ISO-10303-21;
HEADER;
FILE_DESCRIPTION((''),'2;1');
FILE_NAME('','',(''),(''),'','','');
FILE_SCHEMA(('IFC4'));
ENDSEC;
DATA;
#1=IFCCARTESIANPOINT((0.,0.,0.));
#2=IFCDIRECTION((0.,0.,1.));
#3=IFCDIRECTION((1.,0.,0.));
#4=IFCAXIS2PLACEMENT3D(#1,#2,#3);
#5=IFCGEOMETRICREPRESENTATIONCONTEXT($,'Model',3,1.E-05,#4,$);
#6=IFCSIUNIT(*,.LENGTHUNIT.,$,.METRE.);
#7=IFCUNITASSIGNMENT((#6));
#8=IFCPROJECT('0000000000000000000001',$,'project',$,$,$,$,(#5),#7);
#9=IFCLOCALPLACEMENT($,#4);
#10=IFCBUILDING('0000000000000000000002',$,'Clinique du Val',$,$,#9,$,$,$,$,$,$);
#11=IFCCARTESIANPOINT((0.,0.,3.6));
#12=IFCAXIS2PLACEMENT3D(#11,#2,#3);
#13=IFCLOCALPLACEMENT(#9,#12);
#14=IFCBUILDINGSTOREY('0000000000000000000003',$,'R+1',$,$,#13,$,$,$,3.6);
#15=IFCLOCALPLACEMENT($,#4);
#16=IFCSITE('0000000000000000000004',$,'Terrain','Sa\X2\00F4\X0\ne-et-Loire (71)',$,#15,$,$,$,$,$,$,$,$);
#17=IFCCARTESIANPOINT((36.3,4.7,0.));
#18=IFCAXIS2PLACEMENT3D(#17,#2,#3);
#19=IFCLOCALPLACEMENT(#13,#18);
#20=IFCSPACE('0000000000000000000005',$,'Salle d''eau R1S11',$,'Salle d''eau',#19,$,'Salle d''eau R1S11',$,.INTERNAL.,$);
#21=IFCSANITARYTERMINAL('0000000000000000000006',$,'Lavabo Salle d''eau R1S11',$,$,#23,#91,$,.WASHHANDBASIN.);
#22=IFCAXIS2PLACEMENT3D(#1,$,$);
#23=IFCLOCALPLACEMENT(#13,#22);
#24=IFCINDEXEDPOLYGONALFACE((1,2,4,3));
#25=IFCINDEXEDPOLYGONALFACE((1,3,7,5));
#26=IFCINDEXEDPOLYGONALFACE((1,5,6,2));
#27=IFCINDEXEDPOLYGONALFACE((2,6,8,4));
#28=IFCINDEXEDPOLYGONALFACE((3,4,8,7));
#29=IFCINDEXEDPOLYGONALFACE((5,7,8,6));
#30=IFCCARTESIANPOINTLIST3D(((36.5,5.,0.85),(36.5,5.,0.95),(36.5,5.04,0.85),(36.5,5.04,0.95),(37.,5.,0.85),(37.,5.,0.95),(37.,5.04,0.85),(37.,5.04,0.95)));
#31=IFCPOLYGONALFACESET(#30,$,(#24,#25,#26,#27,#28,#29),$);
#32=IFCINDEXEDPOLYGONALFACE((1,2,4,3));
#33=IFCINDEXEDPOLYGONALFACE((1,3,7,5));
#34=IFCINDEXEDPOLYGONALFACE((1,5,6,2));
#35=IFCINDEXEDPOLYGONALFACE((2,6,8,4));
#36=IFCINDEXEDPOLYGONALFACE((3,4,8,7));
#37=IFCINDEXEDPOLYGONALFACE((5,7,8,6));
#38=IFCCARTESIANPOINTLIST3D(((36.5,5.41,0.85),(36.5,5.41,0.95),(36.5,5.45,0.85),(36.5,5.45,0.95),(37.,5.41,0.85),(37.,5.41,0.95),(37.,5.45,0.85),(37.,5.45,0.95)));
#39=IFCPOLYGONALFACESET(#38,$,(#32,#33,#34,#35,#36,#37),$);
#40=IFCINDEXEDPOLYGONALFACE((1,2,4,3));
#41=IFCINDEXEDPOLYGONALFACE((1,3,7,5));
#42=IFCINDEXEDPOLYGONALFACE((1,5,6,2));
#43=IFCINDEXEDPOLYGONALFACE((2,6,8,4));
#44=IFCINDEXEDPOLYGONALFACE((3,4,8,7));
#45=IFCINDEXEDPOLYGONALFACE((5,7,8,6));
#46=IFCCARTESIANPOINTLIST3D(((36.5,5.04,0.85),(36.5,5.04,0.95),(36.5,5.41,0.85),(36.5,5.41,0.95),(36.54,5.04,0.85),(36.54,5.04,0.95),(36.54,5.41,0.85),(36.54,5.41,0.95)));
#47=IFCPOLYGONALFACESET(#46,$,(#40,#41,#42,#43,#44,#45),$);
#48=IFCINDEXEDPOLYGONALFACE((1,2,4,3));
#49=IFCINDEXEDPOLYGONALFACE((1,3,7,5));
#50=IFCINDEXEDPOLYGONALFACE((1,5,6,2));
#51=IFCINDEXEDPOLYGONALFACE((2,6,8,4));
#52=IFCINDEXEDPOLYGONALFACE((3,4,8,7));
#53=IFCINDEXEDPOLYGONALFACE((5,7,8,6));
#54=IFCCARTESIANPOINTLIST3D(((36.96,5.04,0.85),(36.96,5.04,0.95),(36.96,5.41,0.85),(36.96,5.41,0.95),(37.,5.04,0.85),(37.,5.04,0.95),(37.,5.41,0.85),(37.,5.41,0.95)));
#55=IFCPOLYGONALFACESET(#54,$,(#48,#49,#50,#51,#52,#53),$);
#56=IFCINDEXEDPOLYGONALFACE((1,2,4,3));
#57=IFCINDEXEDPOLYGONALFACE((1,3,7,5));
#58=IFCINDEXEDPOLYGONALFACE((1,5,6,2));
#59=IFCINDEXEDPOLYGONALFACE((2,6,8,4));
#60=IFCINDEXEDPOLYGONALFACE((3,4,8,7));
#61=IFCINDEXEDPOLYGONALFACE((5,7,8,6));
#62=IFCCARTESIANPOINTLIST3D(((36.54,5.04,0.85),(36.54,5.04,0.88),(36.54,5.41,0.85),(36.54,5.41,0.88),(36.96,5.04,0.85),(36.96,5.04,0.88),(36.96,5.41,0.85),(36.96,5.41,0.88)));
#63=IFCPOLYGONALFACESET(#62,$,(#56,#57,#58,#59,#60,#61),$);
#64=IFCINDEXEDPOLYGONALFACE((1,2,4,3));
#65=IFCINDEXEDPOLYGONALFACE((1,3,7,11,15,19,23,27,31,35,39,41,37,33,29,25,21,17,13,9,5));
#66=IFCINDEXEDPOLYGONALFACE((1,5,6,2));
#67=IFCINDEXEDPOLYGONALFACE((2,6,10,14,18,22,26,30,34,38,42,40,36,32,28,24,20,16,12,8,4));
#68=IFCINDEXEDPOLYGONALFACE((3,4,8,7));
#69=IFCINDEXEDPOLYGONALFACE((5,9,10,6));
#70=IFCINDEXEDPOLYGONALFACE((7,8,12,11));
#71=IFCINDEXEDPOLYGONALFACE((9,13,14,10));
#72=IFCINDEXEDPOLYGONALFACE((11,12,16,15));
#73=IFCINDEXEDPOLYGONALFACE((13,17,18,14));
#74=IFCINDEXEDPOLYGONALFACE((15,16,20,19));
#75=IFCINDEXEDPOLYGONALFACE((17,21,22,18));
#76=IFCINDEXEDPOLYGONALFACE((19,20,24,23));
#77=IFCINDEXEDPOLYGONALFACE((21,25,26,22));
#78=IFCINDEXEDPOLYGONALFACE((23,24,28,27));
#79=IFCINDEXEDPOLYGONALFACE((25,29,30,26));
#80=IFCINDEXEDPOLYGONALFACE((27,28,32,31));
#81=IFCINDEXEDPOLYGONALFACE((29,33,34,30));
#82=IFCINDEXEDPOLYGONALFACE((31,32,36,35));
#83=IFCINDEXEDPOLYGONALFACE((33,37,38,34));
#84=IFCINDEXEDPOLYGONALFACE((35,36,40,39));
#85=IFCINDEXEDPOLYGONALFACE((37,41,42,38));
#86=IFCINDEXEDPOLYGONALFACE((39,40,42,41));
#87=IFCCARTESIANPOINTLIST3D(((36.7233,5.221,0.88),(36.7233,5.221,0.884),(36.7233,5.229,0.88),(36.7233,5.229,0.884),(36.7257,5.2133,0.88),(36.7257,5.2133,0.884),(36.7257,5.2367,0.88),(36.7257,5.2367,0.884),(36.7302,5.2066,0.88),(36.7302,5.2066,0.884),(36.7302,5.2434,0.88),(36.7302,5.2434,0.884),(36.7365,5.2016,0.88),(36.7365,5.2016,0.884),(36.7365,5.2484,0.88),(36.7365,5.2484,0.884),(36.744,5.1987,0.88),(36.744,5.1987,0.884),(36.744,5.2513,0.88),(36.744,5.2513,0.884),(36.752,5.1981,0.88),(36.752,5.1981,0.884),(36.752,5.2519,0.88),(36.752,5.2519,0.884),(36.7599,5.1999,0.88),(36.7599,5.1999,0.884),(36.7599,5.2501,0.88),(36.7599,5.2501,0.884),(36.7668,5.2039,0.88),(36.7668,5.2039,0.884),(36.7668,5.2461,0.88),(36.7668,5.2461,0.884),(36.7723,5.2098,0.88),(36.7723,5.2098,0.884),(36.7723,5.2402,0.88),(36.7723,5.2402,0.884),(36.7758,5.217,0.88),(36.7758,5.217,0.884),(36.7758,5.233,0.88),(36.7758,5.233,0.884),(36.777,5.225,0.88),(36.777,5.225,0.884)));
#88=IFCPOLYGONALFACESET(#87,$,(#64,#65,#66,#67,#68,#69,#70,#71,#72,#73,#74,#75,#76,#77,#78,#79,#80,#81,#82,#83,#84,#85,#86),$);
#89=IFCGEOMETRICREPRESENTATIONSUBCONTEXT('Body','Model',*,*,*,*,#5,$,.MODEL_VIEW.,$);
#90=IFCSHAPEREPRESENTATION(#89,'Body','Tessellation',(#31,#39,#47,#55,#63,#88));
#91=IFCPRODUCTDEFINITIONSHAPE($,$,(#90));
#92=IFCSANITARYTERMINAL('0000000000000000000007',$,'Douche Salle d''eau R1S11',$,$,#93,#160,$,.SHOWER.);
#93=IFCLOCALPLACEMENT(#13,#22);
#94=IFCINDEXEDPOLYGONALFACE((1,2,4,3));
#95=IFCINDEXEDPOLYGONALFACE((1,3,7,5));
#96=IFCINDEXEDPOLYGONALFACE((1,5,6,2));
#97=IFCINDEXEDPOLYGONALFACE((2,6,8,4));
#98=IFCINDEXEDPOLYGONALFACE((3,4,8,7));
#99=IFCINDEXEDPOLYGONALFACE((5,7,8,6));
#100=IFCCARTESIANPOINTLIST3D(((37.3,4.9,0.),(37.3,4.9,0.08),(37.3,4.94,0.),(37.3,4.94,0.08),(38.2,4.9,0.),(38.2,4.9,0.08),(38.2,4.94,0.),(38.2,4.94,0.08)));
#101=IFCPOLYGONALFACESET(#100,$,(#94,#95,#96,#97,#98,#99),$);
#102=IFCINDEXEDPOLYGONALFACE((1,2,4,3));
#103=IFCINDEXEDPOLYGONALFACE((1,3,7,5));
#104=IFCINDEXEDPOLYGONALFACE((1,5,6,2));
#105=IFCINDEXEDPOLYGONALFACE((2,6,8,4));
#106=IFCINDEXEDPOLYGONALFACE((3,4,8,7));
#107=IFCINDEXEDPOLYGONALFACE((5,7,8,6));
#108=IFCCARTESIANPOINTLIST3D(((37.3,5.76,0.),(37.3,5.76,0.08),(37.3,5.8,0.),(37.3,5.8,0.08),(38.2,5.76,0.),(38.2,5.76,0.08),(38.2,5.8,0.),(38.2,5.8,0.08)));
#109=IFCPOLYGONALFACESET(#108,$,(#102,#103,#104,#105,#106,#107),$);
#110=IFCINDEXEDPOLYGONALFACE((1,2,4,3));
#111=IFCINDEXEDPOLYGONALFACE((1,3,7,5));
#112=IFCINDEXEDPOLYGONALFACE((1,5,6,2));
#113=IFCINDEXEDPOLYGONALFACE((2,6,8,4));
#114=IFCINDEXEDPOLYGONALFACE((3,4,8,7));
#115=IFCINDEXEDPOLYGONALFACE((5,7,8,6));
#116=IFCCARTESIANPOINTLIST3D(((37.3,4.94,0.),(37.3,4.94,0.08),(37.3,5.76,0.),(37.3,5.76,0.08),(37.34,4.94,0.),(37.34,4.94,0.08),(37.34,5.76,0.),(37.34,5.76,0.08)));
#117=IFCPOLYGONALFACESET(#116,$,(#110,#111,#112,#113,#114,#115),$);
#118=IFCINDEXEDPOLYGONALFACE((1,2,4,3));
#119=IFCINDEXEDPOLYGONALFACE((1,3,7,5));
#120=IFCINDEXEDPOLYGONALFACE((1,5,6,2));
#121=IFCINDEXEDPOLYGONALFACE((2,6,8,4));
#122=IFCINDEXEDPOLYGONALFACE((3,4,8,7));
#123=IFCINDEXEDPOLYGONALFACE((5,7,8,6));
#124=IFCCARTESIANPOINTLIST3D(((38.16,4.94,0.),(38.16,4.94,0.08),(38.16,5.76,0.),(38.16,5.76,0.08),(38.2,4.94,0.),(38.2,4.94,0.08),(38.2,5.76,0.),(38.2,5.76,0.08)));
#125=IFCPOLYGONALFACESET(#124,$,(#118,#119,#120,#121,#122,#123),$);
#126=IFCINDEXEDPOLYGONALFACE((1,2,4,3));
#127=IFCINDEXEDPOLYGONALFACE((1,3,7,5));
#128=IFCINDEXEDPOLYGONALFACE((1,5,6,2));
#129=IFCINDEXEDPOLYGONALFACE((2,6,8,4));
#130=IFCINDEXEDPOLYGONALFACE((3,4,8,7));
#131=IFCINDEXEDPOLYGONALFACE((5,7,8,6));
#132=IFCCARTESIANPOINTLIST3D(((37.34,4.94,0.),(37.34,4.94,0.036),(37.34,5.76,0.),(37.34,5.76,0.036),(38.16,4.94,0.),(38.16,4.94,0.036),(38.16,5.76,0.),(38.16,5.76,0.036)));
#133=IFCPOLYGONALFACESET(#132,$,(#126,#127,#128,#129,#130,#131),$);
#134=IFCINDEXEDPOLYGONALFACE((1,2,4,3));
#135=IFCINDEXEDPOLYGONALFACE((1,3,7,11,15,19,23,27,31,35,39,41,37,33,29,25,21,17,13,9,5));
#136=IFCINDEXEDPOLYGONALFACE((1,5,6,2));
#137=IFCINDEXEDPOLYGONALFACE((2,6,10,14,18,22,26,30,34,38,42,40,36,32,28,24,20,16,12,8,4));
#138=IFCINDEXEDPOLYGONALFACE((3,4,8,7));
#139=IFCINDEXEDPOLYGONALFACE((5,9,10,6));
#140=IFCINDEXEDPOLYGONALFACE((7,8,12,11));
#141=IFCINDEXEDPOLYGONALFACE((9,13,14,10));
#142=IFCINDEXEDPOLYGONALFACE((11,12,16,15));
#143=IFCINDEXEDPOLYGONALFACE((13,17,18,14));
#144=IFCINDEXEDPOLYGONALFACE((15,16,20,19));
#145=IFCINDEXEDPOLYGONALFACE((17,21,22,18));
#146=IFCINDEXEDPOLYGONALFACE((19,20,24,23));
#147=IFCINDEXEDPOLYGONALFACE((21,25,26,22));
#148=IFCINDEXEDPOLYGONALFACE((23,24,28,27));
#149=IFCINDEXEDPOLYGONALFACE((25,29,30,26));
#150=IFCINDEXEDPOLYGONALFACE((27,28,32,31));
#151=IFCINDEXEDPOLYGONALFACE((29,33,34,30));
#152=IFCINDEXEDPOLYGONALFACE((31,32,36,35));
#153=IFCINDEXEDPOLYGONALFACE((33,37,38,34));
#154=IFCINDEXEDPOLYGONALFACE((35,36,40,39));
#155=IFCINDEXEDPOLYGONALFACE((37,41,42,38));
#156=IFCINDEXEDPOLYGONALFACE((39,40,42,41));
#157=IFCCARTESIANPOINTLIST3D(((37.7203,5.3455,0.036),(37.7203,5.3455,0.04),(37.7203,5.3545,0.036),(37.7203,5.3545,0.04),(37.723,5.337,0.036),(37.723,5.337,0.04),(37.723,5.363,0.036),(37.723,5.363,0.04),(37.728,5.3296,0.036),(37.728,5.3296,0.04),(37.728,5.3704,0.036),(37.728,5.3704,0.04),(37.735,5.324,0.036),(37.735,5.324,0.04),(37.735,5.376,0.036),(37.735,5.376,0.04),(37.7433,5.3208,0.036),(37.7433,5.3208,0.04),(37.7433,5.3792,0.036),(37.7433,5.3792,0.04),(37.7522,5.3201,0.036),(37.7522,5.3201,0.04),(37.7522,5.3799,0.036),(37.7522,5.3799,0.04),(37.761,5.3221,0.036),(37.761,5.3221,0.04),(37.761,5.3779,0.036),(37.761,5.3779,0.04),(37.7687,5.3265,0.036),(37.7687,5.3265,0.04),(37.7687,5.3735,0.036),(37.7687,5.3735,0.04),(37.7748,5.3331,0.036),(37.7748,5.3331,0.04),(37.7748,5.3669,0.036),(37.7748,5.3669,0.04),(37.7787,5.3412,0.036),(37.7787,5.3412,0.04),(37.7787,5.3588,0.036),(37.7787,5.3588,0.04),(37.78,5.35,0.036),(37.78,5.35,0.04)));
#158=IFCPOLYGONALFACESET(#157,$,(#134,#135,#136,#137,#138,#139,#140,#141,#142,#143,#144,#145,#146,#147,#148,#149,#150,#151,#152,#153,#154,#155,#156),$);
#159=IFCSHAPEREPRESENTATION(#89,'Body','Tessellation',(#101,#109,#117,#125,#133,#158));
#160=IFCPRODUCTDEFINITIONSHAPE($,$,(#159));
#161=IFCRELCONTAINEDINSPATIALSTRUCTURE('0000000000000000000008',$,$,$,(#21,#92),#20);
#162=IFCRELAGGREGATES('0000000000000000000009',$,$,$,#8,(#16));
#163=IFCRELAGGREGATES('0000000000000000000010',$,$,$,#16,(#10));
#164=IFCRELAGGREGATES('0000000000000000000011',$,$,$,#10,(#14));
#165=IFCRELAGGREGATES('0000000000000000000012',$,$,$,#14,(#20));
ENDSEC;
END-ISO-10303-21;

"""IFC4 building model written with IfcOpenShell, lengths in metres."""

from ifc_helpers import new_model, si_unit, frame, frame_2d, origin_with_axes, place, context, subcontext, project, spatial, rectangle, circle, extrude, element, save


model = new_model("IFC4")

# Units and contexts
model_context = context("Model", 3, precision=1e-05, world=origin_with_axes())
body_context = subcontext(model_context, "Body", "Model", "MODEL_VIEW")
ifc_project = project(units=[si_unit("LENGTHUNIT", "METRE")], contexts=[model_context])

# Site, building, storey
site_placement = place(None, origin_with_axes())
site = spatial("IfcSite", under=ifc_project, at=site_placement, Name="Terrain", Description="Saône-et-Loire (71)")
building_placement = place(None, origin_with_axes())
building = spatial("IfcBuilding", under=site, at=building_placement, Name="Clinique du Val")
storey_placement = place(building_placement, frame((0.0, 0.0, 3.6), z_axis=(0.0, 0.0, 1.0), x_axis=(1.0, 0.0, 0.0)))
storey = spatial("IfcBuildingStorey", under=building, at=storey_placement, Name="R+1", Elevation=3.6)

# Shared definitions
space_1_placement = place(storey_placement, frame((36.3, 4.7, 0.0), z_axis=(0.0, 0.0, 1.0), x_axis=(1.0, 0.0, 0.0)))
space_1 = spatial("IfcSpace", under=storey, at=space_1_placement, Name="Salle d'eau R1S11", ObjectType="Salle d'eau", LongName="Salle d'eau R1S11", PredefinedType="INTERNAL")

# Sanitary terminals
sanitary_terminal_1_placement = place(space_1_placement, frame((0.2, 0.3, 0.85), z_axis=(0.0, 0.0, 1.0), x_axis=(1.0, 0.0, 0.0)))
element("IfcSanitaryTerminal", 1, at=sanitary_terminal_1_placement, inside=space_1, Name="Lavabo Salle d'eau R1S11", PredefinedType="WASHHANDBASIN", context=body_context, shape_type="SweptSolid", body=[
    extrude(rectangle(XDim=0.5, YDim=0.04, at=frame_2d((0.25, 0.02))), origin_with_axes(), (0.0, 0.0, 1.0), 0.1),
    extrude(rectangle(XDim=0.5, YDim=0.04, at=frame_2d((0.25, 0.02))), frame((0.0, 0.41, 0.0), z_axis=(0.0, 0.0, 1.0), x_axis=(1.0, 0.0, 0.0)), (0.0, 0.0, 1.0), 0.1),
    extrude(rectangle(XDim=0.04, YDim=0.37, at=frame_2d((0.02, 0.185))), frame((0.0, 0.04, 0.0), z_axis=(0.0, 0.0, 1.0), x_axis=(1.0, 0.0, 0.0)), (0.0, 0.0, 1.0), 0.1),
    extrude(rectangle(XDim=0.04, YDim=0.37, at=frame_2d((0.02, 0.185))), frame((0.46, 0.04, 0.0), z_axis=(0.0, 0.0, 1.0), x_axis=(1.0, 0.0, 0.0)), (0.0, 0.0, 1.0), 0.1),
    extrude(rectangle(XDim=0.42, YDim=0.37, at=frame_2d((0.21, 0.185))), frame((0.04, 0.04, 0.0), z_axis=(0.0, 0.0, 1.0), x_axis=(1.0, 0.0, 0.0)), (0.0, 0.0, 1.0), 0.03),
    extrude(circle(Radius=0.027), frame((0.25, 0.225, 0.03), z_axis=(0.0, 0.0, 1.0), x_axis=(1.0, 0.0, 0.0)), (0.0, 0.0, 1.0), 0.004),
])
sanitary_terminal_2_placement = place(space_1_placement, frame((1.0, 0.2, 0.0), z_axis=(0.0, 0.0, 1.0), x_axis=(1.0, 0.0, 0.0)))
element("IfcSanitaryTerminal", 2, at=sanitary_terminal_2_placement, inside=space_1, Name="Douche Salle d'eau R1S11", PredefinedType="SHOWER", context=body_context, shape_type="SweptSolid", body=[
    extrude(rectangle(XDim=0.9, YDim=0.04, at=frame_2d((0.45, 0.02))), origin_with_axes(), (0.0, 0.0, 1.0), 0.08),
    extrude(rectangle(XDim=0.9, YDim=0.04, at=frame_2d((0.45, 0.02))), frame((0.0, 0.86, 0.0), z_axis=(0.0, 0.0, 1.0), x_axis=(1.0, 0.0, 0.0)), (0.0, 0.0, 1.0), 0.08),
    extrude(rectangle(XDim=0.04, YDim=0.82, at=frame_2d((0.02, 0.41))), frame((0.0, 0.04, 0.0), z_axis=(0.0, 0.0, 1.0), x_axis=(1.0, 0.0, 0.0)), (0.0, 0.0, 1.0), 0.08),
    extrude(rectangle(XDim=0.04, YDim=0.82, at=frame_2d((0.02, 0.41))), frame((0.86, 0.04, 0.0), z_axis=(0.0, 0.0, 1.0), x_axis=(1.0, 0.0, 0.0)), (0.0, 0.0, 1.0), 0.08),
    extrude(rectangle(XDim=0.82, YDim=0.82, at=frame_2d((0.41, 0.41))), frame((0.04, 0.04, 0.0), z_axis=(0.0, 0.0, 1.0), x_axis=(1.0, 0.0, 0.0)), (0.0, 0.0, 1.0), 0.036),
    extrude(circle(Radius=0.03), frame((0.45, 0.45, 0.036), z_axis=(0.0, 0.0, 1.0), x_axis=(1.0, 0.0, 0.0)), (0.0, 0.0, 1.0), 0.004),
])

save(model, "model.ifc")
